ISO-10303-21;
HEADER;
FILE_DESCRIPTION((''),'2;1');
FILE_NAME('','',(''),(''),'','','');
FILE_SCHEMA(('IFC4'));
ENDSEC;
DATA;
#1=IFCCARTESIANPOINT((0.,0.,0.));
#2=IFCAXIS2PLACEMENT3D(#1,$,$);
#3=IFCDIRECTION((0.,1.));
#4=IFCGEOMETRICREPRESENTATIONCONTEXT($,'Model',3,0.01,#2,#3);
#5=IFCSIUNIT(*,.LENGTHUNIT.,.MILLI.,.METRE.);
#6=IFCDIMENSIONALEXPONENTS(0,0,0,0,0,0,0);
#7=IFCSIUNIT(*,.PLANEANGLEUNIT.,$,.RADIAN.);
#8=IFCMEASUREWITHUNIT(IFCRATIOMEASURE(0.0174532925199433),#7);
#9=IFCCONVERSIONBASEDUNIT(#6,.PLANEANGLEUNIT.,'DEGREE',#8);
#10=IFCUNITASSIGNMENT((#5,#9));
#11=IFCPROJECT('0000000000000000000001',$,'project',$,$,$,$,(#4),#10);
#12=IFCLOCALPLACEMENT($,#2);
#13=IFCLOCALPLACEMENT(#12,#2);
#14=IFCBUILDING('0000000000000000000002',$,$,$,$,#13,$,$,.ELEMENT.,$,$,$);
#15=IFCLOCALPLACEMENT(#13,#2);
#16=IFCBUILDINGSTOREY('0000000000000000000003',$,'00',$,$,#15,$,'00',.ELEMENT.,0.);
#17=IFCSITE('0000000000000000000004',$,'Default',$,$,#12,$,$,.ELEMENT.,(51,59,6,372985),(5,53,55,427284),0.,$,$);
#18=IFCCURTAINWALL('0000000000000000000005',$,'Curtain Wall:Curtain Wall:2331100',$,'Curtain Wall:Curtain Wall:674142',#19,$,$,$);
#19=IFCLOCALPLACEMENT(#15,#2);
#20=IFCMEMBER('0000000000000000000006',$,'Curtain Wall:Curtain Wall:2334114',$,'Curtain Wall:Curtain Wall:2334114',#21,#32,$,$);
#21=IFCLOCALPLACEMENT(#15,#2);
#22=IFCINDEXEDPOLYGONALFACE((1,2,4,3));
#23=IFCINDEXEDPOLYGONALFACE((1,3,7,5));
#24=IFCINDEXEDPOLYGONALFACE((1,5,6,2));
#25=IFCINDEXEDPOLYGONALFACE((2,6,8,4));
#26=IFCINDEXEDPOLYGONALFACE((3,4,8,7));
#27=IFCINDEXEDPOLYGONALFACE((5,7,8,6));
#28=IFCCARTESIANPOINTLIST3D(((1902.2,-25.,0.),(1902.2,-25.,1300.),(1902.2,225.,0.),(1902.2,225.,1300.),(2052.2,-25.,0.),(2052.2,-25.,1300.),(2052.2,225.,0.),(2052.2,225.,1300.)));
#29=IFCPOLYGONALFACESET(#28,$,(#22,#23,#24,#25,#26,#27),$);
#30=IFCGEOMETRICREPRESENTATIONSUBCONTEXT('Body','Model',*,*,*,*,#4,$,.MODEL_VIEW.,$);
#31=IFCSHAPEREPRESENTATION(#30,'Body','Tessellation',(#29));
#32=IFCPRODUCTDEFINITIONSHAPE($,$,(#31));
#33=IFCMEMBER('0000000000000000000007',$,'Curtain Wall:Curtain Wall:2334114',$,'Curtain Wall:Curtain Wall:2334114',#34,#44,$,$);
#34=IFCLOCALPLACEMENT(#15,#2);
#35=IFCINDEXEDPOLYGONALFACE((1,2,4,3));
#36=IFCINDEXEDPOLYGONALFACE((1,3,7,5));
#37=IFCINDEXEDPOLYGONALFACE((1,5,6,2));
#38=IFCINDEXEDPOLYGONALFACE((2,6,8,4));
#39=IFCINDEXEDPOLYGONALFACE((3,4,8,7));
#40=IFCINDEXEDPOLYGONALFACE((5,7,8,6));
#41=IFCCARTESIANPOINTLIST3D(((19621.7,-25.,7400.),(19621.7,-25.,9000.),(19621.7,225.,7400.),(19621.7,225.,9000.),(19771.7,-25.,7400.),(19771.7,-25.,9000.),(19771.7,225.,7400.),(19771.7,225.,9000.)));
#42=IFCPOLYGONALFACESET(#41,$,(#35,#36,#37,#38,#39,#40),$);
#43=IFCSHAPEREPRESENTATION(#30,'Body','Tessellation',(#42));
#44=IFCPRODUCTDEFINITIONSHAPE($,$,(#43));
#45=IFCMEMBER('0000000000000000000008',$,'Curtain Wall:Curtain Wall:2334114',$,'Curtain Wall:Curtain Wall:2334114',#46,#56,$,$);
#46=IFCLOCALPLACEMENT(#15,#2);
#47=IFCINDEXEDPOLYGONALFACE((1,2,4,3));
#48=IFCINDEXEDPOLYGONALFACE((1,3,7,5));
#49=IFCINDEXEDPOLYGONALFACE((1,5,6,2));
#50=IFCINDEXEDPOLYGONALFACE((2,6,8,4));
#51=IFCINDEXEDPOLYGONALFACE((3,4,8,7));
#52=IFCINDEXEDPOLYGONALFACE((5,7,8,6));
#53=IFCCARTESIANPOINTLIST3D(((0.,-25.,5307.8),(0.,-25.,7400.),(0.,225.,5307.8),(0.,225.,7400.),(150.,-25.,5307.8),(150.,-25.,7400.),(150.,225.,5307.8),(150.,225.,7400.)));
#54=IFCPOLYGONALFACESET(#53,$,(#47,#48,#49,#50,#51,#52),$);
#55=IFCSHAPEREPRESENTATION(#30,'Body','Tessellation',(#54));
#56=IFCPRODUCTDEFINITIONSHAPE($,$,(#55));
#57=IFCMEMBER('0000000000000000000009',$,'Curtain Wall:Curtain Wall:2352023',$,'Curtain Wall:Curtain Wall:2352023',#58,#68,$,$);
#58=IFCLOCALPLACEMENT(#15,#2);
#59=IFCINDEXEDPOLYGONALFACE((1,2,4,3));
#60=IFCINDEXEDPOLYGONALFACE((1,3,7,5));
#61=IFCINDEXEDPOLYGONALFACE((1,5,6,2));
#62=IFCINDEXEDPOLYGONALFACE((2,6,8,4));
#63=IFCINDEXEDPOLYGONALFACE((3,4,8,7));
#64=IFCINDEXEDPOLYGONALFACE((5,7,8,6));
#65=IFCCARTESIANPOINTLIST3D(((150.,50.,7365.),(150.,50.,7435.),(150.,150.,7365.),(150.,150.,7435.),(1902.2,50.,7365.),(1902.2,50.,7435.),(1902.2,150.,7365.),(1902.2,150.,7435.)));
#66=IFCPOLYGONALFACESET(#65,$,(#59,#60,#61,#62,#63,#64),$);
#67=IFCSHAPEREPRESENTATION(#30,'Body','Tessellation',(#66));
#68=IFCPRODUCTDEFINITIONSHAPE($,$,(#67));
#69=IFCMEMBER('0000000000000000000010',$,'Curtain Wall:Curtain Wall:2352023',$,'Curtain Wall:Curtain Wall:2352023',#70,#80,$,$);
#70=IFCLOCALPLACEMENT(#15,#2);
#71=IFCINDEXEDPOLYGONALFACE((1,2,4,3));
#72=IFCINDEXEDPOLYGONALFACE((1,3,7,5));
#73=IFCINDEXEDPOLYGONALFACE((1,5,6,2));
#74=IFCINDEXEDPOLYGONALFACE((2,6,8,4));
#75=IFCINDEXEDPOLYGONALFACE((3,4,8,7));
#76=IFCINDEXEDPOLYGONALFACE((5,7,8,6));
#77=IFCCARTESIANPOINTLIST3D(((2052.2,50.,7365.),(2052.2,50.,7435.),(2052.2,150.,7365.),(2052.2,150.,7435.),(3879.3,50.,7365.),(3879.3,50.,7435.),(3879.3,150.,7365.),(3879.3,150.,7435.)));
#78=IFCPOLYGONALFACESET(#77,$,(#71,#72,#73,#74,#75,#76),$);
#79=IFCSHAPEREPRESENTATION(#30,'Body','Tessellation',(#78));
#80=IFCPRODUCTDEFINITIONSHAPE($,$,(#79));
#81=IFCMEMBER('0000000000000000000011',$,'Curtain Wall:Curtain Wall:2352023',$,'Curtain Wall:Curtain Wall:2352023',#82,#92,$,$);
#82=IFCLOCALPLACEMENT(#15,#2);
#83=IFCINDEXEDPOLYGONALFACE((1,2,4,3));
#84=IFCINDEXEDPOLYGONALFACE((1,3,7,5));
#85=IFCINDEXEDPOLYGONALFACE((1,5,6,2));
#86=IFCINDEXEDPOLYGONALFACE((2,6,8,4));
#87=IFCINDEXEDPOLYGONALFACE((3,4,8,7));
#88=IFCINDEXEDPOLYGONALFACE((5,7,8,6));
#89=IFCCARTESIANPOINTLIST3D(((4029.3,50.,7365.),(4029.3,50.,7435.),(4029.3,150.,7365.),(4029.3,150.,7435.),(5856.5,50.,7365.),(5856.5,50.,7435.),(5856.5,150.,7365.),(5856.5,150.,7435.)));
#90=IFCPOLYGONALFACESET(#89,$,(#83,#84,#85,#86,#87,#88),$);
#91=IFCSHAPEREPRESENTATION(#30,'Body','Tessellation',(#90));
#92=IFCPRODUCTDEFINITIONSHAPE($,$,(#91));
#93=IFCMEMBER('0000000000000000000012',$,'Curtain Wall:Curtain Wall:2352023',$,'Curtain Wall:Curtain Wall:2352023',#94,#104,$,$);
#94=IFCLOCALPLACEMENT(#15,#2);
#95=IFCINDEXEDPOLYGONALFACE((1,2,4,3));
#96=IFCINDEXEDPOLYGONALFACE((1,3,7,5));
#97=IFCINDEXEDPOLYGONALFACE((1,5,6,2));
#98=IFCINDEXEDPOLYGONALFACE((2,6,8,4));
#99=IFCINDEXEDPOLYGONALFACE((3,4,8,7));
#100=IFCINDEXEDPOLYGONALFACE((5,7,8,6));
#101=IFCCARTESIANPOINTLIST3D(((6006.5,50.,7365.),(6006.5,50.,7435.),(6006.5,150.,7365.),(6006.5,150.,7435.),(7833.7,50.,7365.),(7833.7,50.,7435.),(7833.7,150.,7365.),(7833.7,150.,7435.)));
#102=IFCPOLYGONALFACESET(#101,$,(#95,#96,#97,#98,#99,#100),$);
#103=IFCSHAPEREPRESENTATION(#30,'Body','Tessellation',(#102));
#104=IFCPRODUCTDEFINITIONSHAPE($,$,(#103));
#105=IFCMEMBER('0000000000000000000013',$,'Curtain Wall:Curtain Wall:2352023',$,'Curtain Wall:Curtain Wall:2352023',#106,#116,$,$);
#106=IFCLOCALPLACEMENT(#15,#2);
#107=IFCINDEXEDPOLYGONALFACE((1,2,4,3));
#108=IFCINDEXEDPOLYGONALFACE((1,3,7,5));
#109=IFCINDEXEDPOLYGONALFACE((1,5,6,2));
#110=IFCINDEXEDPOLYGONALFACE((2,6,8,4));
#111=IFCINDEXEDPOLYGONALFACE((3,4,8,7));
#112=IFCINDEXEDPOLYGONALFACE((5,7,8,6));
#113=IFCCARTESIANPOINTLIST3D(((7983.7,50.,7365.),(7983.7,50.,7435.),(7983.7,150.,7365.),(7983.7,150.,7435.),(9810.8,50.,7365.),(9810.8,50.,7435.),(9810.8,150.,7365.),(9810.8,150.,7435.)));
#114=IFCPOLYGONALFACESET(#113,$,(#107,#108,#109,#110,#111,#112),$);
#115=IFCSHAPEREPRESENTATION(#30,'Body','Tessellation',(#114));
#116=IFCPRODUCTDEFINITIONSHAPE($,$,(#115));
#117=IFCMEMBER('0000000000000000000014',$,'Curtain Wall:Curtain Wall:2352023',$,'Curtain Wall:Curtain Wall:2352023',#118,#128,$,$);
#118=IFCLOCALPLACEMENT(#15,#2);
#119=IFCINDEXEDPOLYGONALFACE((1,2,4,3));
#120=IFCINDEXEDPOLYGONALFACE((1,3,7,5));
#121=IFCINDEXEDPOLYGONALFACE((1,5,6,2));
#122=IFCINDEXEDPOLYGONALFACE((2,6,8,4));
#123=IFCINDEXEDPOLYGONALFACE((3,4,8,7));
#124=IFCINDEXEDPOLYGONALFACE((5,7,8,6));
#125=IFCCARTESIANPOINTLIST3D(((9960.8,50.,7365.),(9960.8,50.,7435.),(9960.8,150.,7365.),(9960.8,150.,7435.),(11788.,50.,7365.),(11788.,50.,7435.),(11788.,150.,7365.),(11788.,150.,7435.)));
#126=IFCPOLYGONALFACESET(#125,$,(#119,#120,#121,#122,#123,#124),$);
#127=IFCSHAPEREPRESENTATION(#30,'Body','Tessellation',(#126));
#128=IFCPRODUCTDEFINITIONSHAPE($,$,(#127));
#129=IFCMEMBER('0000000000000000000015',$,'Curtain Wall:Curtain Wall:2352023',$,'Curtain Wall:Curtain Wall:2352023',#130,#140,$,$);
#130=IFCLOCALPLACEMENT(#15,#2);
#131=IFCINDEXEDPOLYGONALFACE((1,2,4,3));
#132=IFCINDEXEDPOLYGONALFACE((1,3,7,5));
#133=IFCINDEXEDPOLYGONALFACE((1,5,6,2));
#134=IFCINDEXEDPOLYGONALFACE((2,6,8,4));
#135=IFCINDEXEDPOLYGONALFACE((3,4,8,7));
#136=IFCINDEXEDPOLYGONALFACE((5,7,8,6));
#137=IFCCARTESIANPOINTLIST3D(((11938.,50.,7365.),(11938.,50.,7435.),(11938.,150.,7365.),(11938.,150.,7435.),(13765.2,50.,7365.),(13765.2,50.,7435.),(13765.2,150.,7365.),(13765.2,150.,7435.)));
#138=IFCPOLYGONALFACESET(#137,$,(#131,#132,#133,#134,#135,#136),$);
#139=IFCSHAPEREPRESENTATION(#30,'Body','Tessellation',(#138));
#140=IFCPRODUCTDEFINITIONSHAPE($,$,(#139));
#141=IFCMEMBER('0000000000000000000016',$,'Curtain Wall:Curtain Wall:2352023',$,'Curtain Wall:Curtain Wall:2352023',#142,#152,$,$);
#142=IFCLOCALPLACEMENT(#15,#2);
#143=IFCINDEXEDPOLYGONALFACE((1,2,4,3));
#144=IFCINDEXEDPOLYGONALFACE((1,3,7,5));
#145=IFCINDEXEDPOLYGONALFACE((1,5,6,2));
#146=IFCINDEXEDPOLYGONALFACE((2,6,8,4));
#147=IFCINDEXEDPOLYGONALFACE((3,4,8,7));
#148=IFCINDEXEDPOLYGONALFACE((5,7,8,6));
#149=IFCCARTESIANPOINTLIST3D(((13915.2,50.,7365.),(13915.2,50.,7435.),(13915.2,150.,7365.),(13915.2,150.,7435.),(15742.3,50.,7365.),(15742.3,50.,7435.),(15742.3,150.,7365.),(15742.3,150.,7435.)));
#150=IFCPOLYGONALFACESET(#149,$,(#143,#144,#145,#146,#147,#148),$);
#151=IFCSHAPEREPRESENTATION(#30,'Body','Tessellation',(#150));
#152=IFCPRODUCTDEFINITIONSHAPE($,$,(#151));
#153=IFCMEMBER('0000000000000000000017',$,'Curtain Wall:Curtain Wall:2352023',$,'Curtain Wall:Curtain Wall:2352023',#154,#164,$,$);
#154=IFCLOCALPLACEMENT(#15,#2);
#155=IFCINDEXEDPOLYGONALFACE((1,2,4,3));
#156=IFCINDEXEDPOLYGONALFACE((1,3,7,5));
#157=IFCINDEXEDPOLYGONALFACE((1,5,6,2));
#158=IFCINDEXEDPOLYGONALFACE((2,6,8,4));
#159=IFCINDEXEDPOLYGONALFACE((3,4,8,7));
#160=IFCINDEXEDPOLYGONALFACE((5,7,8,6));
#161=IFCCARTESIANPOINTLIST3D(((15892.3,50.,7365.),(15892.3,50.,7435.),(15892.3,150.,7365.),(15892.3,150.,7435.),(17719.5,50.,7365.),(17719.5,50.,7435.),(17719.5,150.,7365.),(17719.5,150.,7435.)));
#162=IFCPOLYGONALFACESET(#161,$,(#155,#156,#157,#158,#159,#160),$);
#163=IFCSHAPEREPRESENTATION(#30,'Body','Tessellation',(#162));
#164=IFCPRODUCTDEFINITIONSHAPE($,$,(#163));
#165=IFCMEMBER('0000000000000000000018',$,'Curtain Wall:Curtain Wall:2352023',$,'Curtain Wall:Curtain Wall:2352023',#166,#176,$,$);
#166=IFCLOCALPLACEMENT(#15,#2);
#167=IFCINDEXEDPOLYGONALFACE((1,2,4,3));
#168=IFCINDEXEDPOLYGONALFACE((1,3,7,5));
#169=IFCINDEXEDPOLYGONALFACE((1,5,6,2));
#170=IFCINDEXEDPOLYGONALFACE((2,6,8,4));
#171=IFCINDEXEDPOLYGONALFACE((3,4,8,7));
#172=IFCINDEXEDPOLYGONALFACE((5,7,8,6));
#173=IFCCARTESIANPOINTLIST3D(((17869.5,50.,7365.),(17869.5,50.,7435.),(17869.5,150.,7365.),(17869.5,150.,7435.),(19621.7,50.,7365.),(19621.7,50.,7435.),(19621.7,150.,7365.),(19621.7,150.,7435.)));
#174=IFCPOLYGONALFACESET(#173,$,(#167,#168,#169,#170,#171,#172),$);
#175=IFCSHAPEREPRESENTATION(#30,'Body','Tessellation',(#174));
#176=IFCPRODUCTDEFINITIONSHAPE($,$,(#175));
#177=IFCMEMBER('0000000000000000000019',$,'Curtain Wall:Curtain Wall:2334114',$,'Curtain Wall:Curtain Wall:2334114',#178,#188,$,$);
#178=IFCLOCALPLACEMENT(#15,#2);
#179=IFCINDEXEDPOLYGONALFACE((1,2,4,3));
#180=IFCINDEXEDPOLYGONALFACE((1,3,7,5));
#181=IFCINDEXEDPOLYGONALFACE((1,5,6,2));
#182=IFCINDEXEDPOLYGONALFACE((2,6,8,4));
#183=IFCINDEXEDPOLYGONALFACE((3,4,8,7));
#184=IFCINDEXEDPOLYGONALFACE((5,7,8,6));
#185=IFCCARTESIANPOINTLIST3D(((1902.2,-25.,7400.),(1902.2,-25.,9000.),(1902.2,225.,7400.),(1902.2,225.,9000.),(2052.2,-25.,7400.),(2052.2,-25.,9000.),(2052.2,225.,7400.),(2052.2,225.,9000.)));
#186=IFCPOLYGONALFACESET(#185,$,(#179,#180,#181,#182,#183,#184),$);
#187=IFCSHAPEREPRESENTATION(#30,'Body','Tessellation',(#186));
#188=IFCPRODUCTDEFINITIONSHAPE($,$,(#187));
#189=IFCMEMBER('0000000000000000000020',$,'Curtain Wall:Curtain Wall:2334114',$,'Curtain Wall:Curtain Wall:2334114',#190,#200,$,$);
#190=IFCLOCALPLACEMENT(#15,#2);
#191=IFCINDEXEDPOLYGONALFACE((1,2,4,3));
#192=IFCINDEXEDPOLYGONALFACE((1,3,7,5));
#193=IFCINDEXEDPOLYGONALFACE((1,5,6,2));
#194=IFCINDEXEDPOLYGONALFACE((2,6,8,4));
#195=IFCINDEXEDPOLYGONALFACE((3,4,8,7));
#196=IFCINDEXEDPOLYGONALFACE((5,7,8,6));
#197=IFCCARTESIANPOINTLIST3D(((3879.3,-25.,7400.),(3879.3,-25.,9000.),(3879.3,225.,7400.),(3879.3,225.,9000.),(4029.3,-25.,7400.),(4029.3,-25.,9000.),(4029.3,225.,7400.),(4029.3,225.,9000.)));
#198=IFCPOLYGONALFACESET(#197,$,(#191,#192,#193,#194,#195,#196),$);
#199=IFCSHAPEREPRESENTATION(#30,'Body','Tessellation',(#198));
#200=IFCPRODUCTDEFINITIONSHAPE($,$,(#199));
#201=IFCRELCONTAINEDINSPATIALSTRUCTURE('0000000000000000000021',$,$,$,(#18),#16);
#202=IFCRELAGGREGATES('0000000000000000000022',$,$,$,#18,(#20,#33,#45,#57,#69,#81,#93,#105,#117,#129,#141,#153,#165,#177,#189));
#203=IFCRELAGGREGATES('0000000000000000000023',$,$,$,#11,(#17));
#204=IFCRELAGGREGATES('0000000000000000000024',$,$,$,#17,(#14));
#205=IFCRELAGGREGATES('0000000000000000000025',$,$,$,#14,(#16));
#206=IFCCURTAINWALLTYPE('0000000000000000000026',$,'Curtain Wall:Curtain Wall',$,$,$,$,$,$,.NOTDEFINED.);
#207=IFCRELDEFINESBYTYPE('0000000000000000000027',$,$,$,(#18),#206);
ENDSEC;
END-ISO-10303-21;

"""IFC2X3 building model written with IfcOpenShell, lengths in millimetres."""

from ifc_helpers import new_model, entity, si_unit, converted_unit, direction, frame, frame_2d, origin, origin_2d_with_axis, place, context, subcontext, project, spatial, rectangle, extrude, type_object, element, aggregate, save


model = new_model("IFC2X3")

# Units and contexts
model_context = context("Model", 3, precision=0.01, world=origin(), true_north=direction((0.0, 1.0)))
body_context = subcontext(model_context, "Body", "Model", "MODEL_VIEW")
ifc_project = project(units=[si_unit("LENGTHUNIT", "METRE", prefix="MILLI"), converted_unit("PLANEANGLEUNIT", "DEGREE", entity("IfcRatioMeasure", 0.0174532925199433), si_unit("PLANEANGLEUNIT", "RADIAN"), dimensions=[0, 0, 0, 0, 0, 0, 0])], contexts=[model_context])

# Site, building, storey
site_placement = place(None, origin())
site = spatial("IfcSite", under=ifc_project, at=site_placement, Name="Default", CompositionType="ELEMENT", RefLatitude=(51, 59, 6, 372985), RefLongitude=(5, 53, 55, 427284), RefElevation=0.0)
building_placement = place(site_placement, origin())
building = spatial("IfcBuilding", under=site, at=building_placement, CompositionType="ELEMENT")
storey_placement = place(building_placement, origin())
storey = spatial("IfcBuildingStorey", under=building, at=storey_placement, Name="00", LongName="00", CompositionType="ELEMENT", Elevation=0.0)

# Curtain wall, members
curtain_wall_type = type_object("IfcCurtainWallType", Name="Curtain Wall:Curtain Wall", PredefinedType="NOTDEFINED")
curtain_wall_placement = place(storey_placement, origin())
curtain_wall = element("IfcCurtainWall", 1, at=curtain_wall_placement, inside=storey, type_object=curtain_wall_type, Name="Curtain Wall:Curtain Wall:2331100", ObjectType="Curtain Wall:Curtain Wall:674142")
member_1_placement = place(curtain_wall_placement, origin())
member_1 = element("IfcMember", 2, at=member_1_placement, Name="Curtain Wall:Curtain Wall:2334114", ObjectType="Curtain Wall:Curtain Wall:2334114", context=body_context, shape_type="SweptSolid", body=[
    extrude(rectangle(XDim=150.0, YDim=250.0, at=frame_2d((0.0, 0.0), x_axis=(1.0, 0.0))), frame((1977.2, 100.0, 0.0), z_axis=(0.0, 0.0, 1.0), x_axis=(-1.0, 0.0, 0.0)), (0.0, 0.0, 1.0), 1300.0),
])
member_2_placement = place(curtain_wall_placement, origin())
member_2 = element("IfcMember", 3, at=member_2_placement, Name="Curtain Wall:Curtain Wall:2334114", ObjectType="Curtain Wall:Curtain Wall:2334114", context=body_context, shape_type="SweptSolid", body=[
    extrude(rectangle(XDim=150.0, YDim=250.0, at=origin_2d_with_axis()), frame((19696.7, 100.0, 7400.0), z_axis=(0.0, 0.0, 1.0), x_axis=(-1.0, 0.0, 0.0)), (0.0, 0.0, 1.0), 1600.0),
])
member_3_placement = place(curtain_wall_placement, origin())
member_3 = element("IfcMember", 4, at=member_3_placement, Name="Curtain Wall:Curtain Wall:2334114", ObjectType="Curtain Wall:Curtain Wall:2334114", context=body_context, shape_type="SweptSolid", body=[
    extrude(rectangle(XDim=150.0, YDim=250.0, at=origin_2d_with_axis()), frame((75.0, 100.0, 7400.0), z_axis=(0.0, 0.0, -1.0), x_axis=(-1.0, 0.0, 0.0)), (0.0, 0.0, 1.0), 2092.2),
])
member_4_placement = place(curtain_wall_placement, origin())
member_4 = element("IfcMember", 5, at=member_4_placement, Name="Curtain Wall:Curtain Wall:2352023", ObjectType="Curtain Wall:Curtain Wall:2352023", context=body_context, shape_type="SweptSolid", body=[
    extrude(rectangle(XDim=70.0, YDim=100.0, at=frame_2d((0.0, 0.0), x_axis=(1.0, 0.0))), frame((1902.2, 100.0, 7400.0), z_axis=(-1.0, 0.0, 0.0), x_axis=(0.0, 0.0, -1.0)), (0.0, 0.0, 1.0), 1752.2),
])
member_5_placement = place(curtain_wall_placement, origin())
member_5 = element("IfcMember", 6, at=member_5_placement, Name="Curtain Wall:Curtain Wall:2352023", ObjectType="Curtain Wall:Curtain Wall:2352023", context=body_context, shape_type="SweptSolid", body=[
    extrude(rectangle(XDim=70.0, YDim=100.0, at=frame_2d((0.0, 0.0), x_axis=(1.0, 0.0))), frame((3879.3, 100.0, 7400.0), z_axis=(-1.0, 0.0, 0.0), x_axis=(0.0, 0.0, -1.0)), (0.0, 0.0, 1.0), 1827.2),
])
member_6_placement = place(curtain_wall_placement, origin())
member_6 = element("IfcMember", 7, at=member_6_placement, Name="Curtain Wall:Curtain Wall:2352023", ObjectType="Curtain Wall:Curtain Wall:2352023", context=body_context, shape_type="SweptSolid", body=[
    extrude(rectangle(XDim=70.0, YDim=100.0, at=frame_2d((0.0, 0.0), x_axis=(1.0, 0.0))), frame((5856.5, 100.0, 7400.0), z_axis=(-1.0, 0.0, 0.0), x_axis=(0.0, 0.0, -1.0)), (0.0, 0.0, 1.0), 1827.2),
])
member_7_placement = place(curtain_wall_placement, origin())
member_7 = element("IfcMember", 8, at=member_7_placement, Name="Curtain Wall:Curtain Wall:2352023", ObjectType="Curtain Wall:Curtain Wall:2352023", context=body_context, shape_type="SweptSolid", body=[
    extrude(rectangle(XDim=70.0, YDim=100.0, at=frame_2d((0.0, 0.0), x_axis=(1.0, 0.0))), frame((7833.7, 100.0, 7400.0), z_axis=(-1.0, 0.0, 0.0), x_axis=(0.0, 0.0, -1.0)), (0.0, 0.0, 1.0), 1827.2),
])
member_8_placement = place(curtain_wall_placement, origin())
member_8 = element("IfcMember", 9, at=member_8_placement, Name="Curtain Wall:Curtain Wall:2352023", ObjectType="Curtain Wall:Curtain Wall:2352023", context=body_context, shape_type="SweptSolid", body=[
    extrude(rectangle(XDim=70.0, YDim=100.0, at=frame_2d((0.0, 0.0), x_axis=(1.0, 0.0))), frame((9810.8, 100.0, 7400.0), z_axis=(-1.0, 0.0, 0.0), x_axis=(0.0, 0.0, -1.0)), (0.0, 0.0, 1.0), 1827.2),
])
member_9_placement = place(curtain_wall_placement, origin())
member_9 = element("IfcMember", 10, at=member_9_placement, Name="Curtain Wall:Curtain Wall:2352023", ObjectType="Curtain Wall:Curtain Wall:2352023", context=body_context, shape_type="SweptSolid", body=[
    extrude(rectangle(XDim=70.0, YDim=100.0, at=frame_2d((0.0, 0.0), x_axis=(1.0, 0.0))), frame((11788.0, 100.0, 7400.0), z_axis=(-1.0, 0.0, 0.0), x_axis=(0.0, 0.0, -1.0)), (0.0, 0.0, 1.0), 1827.2),
])
member_10_placement = place(curtain_wall_placement, origin())
member_10 = element("IfcMember", 11, at=member_10_placement, Name="Curtain Wall:Curtain Wall:2352023", ObjectType="Curtain Wall:Curtain Wall:2352023", context=body_context, shape_type="SweptSolid", body=[
    extrude(rectangle(XDim=70.0, YDim=100.0, at=frame_2d((0.0, 0.0), x_axis=(1.0, 0.0))), frame((13765.2, 100.0, 7400.0), z_axis=(-1.0, 0.0, 0.0), x_axis=(0.0, 0.0, -1.0)), (0.0, 0.0, 1.0), 1827.2),
])
member_11_placement = place(curtain_wall_placement, origin())
member_11 = element("IfcMember", 12, at=member_11_placement, Name="Curtain Wall:Curtain Wall:2352023", ObjectType="Curtain Wall:Curtain Wall:2352023", context=body_context, shape_type="SweptSolid", body=[
    extrude(rectangle(XDim=70.0, YDim=100.0, at=frame_2d((0.0, 0.0), x_axis=(1.0, 0.0))), frame((15742.3, 100.0, 7400.0), z_axis=(-1.0, 0.0, 0.0), x_axis=(0.0, 0.0, -1.0)), (0.0, 0.0, 1.0), 1827.2),
])
member_12_placement = place(curtain_wall_placement, origin())
member_12 = element("IfcMember", 13, at=member_12_placement, Name="Curtain Wall:Curtain Wall:2352023", ObjectType="Curtain Wall:Curtain Wall:2352023", context=body_context, shape_type="SweptSolid", body=[
    extrude(rectangle(XDim=70.0, YDim=100.0, at=frame_2d((0.0, 0.0), x_axis=(1.0, 0.0))), frame((17719.5, 100.0, 7400.0), z_axis=(-1.0, 0.0, 0.0), x_axis=(0.0, 0.0, -1.0)), (0.0, 0.0, 1.0), 1827.2),
])
member_13_placement = place(curtain_wall_placement, origin())
member_13 = element("IfcMember", 14, at=member_13_placement, Name="Curtain Wall:Curtain Wall:2352023", ObjectType="Curtain Wall:Curtain Wall:2352023", context=body_context, shape_type="SweptSolid", body=[
    extrude(rectangle(XDim=70.0, YDim=100.0, at=frame_2d((0.0, 0.0), x_axis=(1.0, 0.0))), frame((19621.7, 100.0, 7400.0), z_axis=(-1.0, 0.0, 0.0), x_axis=(0.0, 0.0, -1.0)), (0.0, 0.0, 1.0), 1752.2),
])
member_14_placement = place(curtain_wall_placement, origin())
member_14 = element("IfcMember", 15, at=member_14_placement, Name="Curtain Wall:Curtain Wall:2334114", ObjectType="Curtain Wall:Curtain Wall:2334114", context=body_context, shape_type="SweptSolid", body=[
    extrude(rectangle(XDim=150.0, YDim=250.0, at=frame_2d((0.0, 0.0), x_axis=(1.0, 0.0))), frame((1977.2, 100.0, 7400.0), z_axis=(0.0, 0.0, 1.0), x_axis=(-1.0, 0.0, 0.0)), (0.0, 0.0, 1.0), 1600.0),
])
member_15_placement = place(curtain_wall_placement, origin())
member_15 = element("IfcMember", 16, at=member_15_placement, Name="Curtain Wall:Curtain Wall:2334114", ObjectType="Curtain Wall:Curtain Wall:2334114", context=body_context, shape_type="SweptSolid", body=[
    extrude(rectangle(XDim=150.0, YDim=250.0, at=frame_2d((0.0, 0.0), x_axis=(1.0, 0.0))), frame((3954.3, 100.0, 7400.0), z_axis=(0.0, 0.0, 1.0), x_axis=(-1.0, 0.0, 0.0)), (0.0, 0.0, 1.0), 1600.0),
])
aggregate(curtain_wall, [member_1, member_2, member_3, member_4, member_5, member_6, member_7, member_8, member_9, member_10, member_11, member_12, member_13, member_14, member_15])

save(model, "model.ifc")
